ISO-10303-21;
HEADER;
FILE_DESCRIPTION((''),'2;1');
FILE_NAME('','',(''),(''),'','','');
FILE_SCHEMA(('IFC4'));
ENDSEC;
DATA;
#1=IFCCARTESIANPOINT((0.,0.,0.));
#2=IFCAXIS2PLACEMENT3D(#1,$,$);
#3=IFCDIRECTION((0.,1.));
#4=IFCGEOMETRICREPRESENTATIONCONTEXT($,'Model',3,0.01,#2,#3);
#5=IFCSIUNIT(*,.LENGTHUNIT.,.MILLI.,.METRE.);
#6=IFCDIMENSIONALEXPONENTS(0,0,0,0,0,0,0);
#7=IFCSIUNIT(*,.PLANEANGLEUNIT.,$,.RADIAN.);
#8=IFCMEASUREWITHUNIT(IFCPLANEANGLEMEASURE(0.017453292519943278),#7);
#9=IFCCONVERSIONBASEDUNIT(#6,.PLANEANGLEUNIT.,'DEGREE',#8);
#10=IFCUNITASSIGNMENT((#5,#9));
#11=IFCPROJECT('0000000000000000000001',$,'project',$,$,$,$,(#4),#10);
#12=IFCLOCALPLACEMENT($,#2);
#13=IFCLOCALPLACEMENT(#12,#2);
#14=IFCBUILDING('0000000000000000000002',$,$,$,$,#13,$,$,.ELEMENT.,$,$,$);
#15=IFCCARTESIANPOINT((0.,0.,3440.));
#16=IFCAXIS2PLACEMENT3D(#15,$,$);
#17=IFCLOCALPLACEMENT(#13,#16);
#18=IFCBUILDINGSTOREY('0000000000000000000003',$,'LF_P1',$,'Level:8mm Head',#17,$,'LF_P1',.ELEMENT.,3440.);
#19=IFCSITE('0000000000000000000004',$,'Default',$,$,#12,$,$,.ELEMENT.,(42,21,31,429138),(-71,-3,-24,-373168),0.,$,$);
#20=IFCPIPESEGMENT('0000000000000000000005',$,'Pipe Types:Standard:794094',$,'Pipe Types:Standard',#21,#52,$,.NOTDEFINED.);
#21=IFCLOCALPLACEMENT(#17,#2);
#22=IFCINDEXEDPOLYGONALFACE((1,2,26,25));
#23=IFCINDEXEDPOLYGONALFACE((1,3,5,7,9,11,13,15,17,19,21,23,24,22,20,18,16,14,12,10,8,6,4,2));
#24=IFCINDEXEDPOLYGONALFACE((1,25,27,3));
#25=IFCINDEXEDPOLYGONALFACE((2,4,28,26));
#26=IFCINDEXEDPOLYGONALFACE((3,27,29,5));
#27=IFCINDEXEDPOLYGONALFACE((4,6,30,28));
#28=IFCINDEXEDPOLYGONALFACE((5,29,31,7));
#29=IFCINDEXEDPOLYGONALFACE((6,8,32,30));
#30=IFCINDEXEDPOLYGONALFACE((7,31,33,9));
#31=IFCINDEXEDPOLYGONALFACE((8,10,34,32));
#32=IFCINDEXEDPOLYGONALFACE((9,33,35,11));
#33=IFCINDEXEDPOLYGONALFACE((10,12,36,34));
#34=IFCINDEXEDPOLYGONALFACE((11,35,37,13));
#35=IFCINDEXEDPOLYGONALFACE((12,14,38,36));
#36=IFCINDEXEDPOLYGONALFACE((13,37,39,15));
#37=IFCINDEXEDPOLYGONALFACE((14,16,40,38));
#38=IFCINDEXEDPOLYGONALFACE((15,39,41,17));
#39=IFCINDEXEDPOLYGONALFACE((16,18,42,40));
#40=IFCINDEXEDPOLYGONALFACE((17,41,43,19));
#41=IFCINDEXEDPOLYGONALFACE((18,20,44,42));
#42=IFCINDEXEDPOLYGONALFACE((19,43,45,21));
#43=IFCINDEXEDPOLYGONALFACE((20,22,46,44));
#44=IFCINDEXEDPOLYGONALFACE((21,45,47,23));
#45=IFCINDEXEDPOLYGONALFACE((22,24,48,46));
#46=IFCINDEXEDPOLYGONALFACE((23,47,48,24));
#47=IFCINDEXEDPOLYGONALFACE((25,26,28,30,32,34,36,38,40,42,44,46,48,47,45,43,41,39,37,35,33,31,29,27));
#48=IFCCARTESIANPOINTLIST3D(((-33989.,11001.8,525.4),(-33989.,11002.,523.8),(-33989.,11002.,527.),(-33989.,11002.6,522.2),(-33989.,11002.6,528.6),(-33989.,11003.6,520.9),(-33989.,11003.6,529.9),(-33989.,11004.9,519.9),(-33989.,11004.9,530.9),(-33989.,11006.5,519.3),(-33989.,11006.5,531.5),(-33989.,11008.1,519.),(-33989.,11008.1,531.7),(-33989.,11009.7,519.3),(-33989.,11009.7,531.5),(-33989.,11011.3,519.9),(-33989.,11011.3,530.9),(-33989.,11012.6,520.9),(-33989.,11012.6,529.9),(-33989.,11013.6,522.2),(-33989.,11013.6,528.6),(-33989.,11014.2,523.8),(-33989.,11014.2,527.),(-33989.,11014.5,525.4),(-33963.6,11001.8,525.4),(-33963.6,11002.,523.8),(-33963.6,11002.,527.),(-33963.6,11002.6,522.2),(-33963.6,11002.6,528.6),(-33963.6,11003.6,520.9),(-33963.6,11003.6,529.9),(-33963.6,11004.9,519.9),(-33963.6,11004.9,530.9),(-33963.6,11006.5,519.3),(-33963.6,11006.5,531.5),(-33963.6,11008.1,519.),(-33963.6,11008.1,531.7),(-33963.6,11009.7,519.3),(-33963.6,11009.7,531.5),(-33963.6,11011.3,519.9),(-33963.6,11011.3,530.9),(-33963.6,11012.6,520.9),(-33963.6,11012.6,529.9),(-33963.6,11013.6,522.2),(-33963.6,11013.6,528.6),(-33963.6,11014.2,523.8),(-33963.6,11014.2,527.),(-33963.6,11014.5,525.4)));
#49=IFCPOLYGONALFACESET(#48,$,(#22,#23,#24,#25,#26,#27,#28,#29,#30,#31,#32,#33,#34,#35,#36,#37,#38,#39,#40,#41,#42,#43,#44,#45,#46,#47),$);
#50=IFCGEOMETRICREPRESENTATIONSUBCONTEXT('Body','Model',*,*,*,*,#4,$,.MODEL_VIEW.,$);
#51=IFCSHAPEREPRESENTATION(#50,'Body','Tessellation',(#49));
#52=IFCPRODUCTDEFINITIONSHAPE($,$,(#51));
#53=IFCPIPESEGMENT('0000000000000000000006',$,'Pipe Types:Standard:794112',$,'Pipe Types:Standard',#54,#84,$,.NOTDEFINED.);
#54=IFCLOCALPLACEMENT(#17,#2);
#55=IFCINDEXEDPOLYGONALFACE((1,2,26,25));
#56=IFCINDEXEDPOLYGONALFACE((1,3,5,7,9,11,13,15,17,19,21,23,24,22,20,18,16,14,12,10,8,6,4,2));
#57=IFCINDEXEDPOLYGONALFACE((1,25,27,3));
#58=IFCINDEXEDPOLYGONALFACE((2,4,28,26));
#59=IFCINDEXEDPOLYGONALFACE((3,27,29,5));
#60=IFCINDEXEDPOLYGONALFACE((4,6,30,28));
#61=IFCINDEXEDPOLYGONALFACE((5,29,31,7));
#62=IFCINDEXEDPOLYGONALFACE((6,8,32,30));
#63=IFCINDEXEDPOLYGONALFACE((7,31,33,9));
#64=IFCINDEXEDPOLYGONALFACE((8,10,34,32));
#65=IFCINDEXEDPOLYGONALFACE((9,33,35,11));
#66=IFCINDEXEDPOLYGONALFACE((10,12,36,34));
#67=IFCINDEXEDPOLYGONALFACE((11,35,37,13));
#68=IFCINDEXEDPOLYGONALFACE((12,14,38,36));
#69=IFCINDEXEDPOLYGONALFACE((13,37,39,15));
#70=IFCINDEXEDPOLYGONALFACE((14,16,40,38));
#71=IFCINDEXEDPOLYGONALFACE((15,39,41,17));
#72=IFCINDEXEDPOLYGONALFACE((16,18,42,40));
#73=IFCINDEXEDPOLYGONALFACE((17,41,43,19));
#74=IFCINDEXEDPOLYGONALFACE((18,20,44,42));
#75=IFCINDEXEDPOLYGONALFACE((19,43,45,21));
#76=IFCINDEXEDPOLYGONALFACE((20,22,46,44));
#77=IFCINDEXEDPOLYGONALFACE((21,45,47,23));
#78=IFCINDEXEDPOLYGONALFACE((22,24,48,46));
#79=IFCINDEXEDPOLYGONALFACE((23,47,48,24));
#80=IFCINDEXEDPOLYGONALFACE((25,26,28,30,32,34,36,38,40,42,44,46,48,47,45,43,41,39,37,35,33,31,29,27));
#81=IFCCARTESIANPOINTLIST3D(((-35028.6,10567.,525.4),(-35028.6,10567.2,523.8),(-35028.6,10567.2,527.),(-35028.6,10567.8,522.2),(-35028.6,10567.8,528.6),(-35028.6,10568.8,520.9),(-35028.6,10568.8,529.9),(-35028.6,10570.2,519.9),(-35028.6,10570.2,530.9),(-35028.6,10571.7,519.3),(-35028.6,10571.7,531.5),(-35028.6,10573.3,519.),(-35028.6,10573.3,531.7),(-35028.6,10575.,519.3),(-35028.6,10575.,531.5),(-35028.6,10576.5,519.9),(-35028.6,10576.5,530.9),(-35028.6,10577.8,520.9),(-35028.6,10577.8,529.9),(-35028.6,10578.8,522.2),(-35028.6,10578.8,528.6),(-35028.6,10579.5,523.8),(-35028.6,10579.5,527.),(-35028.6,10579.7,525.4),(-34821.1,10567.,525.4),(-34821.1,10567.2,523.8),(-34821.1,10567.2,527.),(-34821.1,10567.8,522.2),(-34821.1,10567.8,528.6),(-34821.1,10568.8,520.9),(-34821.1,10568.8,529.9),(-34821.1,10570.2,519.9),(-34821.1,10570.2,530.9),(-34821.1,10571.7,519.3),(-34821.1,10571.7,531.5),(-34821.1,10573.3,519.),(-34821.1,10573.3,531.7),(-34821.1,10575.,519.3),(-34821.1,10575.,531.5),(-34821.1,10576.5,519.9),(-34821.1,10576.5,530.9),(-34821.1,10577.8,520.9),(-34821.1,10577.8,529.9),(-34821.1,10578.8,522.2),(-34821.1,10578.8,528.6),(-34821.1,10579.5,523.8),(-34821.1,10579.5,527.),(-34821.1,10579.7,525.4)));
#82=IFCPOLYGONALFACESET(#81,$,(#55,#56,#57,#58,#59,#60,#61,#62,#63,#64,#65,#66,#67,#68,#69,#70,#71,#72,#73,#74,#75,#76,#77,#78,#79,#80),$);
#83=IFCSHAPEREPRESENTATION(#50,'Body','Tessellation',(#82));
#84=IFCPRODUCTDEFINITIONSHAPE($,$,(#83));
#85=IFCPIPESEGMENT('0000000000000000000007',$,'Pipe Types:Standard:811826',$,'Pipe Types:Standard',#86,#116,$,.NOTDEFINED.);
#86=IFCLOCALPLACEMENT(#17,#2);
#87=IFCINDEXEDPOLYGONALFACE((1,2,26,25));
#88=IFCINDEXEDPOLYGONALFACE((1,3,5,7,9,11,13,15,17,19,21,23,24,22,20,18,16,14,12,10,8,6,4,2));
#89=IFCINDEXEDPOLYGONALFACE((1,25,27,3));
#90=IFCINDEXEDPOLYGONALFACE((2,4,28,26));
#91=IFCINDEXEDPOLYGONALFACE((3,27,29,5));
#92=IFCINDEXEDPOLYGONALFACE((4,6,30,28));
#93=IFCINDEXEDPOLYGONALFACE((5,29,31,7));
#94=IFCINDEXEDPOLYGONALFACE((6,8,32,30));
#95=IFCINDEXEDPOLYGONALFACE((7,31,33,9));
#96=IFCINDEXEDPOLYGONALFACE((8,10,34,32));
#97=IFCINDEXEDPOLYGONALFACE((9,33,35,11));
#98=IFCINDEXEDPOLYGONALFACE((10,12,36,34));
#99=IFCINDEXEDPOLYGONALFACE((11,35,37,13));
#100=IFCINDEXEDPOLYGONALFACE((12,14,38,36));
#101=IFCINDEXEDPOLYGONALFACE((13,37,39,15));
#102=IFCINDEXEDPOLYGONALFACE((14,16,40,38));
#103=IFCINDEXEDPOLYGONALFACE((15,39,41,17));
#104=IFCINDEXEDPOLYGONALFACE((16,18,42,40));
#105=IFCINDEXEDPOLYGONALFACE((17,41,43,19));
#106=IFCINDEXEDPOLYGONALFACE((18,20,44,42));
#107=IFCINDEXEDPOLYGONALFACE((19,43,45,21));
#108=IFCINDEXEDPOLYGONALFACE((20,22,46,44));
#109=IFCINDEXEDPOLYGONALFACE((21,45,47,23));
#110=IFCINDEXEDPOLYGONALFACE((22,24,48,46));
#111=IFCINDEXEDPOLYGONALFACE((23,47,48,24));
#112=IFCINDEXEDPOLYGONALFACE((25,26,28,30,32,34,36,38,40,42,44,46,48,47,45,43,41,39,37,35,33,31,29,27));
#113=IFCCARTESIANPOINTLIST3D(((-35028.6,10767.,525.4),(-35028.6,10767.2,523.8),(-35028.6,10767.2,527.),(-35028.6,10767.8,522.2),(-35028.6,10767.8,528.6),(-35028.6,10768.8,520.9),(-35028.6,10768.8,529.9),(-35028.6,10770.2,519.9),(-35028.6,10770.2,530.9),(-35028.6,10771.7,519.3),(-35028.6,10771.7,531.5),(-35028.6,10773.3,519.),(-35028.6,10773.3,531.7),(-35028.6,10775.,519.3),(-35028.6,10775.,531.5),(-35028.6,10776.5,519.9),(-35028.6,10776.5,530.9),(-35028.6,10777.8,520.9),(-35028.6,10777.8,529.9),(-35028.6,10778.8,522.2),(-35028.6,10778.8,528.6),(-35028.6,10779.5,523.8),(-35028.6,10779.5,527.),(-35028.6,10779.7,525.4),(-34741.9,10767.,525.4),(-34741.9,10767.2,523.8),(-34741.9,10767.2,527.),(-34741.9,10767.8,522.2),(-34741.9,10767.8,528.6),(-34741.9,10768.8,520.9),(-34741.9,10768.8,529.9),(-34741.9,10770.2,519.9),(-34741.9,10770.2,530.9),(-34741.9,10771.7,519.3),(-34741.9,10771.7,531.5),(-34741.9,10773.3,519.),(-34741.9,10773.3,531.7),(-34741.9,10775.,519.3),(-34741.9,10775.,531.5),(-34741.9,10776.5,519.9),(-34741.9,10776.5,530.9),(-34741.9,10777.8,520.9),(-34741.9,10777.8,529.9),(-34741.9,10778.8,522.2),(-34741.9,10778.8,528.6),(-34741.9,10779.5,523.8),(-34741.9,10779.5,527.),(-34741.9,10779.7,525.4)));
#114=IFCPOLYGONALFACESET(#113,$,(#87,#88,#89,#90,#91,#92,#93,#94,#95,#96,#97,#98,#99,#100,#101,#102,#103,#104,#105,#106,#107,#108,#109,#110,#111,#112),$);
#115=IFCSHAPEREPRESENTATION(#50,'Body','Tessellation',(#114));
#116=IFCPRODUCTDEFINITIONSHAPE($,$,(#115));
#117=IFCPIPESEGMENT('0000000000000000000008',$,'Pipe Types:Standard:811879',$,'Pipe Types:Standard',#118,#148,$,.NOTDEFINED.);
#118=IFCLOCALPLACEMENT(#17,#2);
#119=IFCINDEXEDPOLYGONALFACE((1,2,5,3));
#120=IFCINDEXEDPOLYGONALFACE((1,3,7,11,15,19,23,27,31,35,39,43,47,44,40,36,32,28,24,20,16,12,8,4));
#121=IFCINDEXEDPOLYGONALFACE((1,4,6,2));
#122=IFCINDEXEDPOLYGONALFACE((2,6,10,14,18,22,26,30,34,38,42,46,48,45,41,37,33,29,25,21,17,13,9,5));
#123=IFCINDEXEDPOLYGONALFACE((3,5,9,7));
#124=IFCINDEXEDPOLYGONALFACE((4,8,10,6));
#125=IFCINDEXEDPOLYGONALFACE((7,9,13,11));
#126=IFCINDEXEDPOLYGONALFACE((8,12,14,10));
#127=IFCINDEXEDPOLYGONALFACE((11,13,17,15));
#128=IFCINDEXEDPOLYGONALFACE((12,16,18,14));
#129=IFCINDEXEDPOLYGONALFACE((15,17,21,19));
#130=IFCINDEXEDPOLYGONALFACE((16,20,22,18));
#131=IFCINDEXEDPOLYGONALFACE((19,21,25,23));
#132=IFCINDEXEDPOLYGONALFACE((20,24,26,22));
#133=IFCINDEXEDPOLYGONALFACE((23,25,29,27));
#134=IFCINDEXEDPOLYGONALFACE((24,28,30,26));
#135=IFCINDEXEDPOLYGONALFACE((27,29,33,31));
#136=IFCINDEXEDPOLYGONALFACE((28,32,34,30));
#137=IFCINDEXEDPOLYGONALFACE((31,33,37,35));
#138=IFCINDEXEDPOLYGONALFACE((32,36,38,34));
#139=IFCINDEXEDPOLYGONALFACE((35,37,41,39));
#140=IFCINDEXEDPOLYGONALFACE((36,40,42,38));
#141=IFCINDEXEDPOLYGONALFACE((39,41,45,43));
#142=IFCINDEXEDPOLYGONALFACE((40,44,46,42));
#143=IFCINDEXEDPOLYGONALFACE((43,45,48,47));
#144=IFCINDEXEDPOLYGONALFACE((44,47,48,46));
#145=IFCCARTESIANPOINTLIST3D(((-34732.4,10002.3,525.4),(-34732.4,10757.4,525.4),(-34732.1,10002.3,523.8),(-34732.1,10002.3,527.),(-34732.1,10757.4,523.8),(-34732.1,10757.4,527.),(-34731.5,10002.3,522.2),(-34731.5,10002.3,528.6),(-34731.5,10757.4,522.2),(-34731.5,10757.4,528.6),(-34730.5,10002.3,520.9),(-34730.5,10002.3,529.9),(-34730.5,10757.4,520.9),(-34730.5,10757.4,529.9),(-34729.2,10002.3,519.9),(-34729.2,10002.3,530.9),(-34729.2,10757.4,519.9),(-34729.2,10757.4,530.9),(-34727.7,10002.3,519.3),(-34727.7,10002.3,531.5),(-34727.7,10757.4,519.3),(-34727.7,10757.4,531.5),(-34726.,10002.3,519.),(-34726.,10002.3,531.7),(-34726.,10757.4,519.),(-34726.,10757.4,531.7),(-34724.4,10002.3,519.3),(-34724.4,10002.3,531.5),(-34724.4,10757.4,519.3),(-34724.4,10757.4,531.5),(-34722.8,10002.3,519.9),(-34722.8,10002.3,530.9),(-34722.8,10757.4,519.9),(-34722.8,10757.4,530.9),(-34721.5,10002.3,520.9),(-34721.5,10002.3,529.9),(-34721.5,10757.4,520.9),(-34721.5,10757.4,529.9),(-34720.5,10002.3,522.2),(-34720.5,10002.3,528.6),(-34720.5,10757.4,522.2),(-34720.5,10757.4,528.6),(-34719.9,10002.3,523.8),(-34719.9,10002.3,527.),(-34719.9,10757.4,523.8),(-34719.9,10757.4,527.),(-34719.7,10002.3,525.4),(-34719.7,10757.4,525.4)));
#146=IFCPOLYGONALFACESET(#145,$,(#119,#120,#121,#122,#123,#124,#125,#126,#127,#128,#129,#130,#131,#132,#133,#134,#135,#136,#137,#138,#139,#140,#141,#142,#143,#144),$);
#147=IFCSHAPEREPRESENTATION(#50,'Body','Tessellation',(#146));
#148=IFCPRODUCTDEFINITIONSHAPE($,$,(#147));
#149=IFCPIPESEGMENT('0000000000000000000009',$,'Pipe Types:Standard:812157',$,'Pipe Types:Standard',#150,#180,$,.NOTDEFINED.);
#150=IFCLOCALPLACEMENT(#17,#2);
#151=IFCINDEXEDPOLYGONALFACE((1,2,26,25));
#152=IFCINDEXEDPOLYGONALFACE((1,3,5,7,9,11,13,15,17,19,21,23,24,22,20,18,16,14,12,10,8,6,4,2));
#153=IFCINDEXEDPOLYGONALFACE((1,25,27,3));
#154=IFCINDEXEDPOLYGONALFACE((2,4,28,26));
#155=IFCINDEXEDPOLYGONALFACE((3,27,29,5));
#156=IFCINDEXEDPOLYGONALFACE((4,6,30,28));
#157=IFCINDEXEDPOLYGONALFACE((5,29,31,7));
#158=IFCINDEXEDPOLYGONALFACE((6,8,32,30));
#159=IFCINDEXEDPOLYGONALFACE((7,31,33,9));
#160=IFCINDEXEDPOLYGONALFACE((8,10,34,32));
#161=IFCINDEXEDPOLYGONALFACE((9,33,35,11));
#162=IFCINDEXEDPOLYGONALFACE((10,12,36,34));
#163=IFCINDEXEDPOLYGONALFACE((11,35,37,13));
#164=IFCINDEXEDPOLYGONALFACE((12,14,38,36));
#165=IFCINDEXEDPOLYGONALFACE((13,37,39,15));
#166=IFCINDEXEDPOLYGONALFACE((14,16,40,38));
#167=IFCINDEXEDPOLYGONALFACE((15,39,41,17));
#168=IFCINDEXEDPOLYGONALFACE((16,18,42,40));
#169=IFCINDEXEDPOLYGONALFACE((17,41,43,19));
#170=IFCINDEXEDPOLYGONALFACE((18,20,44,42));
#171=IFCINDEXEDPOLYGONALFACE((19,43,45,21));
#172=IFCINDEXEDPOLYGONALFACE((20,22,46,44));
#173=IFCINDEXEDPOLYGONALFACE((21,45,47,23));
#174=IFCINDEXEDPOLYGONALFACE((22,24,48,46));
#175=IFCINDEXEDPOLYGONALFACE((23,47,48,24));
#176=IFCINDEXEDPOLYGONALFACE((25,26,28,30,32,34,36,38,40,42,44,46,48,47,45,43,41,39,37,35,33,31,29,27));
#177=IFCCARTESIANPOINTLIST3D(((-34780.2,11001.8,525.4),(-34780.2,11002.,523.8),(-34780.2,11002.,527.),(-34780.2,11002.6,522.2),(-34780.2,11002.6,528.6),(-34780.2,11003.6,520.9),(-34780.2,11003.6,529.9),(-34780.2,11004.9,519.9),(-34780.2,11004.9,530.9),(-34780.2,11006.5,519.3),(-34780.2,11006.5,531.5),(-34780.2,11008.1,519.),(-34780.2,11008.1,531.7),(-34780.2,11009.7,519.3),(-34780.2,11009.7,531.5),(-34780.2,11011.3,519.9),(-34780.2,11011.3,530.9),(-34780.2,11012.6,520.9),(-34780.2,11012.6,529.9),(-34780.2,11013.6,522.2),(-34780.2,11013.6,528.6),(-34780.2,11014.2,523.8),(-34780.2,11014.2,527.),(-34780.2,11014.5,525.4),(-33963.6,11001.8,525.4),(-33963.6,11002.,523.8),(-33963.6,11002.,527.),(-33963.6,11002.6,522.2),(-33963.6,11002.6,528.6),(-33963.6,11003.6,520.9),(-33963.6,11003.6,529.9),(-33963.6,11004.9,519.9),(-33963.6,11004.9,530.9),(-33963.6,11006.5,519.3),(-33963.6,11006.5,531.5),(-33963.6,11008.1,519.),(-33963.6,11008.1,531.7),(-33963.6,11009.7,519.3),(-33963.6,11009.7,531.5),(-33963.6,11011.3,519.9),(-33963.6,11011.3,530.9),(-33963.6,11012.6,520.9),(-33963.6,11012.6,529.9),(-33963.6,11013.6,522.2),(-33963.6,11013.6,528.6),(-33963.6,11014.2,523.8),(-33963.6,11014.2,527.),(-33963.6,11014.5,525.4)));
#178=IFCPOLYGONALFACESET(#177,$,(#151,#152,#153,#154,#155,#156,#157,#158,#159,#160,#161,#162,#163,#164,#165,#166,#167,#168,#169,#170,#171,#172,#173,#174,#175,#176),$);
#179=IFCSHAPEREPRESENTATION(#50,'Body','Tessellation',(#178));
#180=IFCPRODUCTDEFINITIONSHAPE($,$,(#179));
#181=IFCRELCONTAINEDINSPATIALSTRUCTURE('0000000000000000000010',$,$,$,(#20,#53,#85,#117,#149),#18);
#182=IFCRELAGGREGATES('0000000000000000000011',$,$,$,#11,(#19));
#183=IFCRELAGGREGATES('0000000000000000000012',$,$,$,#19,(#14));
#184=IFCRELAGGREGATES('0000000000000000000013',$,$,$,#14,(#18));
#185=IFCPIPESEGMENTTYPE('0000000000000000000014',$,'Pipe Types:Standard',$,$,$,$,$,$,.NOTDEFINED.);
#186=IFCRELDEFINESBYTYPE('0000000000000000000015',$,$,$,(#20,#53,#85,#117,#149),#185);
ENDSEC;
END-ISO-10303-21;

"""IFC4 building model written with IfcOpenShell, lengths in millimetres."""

from ifc_helpers import new_model, entity, si_unit, converted_unit, direction, frame, origin, place, context, subcontext, project, spatial, arc, indexed_curve, outline, extrude, type_object, element, save


model = new_model("IFC4")

# Units and contexts
model_context = context("Model", 3, precision=0.01, world=origin(), true_north=direction((0.0, 1.0)))
body_context = subcontext(model_context, "Body", "Model", "MODEL_VIEW")
ifc_project = project(units=[si_unit("LENGTHUNIT", "METRE", prefix="MILLI"), converted_unit("PLANEANGLEUNIT", "DEGREE", entity("IfcPlaneAngleMeasure", 0.017453292519943278), si_unit("PLANEANGLEUNIT", "RADIAN"), dimensions=[0, 0, 0, 0, 0, 0, 0])], contexts=[model_context])

# Site, building, storey
site_placement = place(None, origin())
site = spatial("IfcSite", under=ifc_project, at=site_placement, Name="Default", CompositionType="ELEMENT", RefLatitude=(42, 21, 31, 429138), RefLongitude=(-71, -3, -24, -373168), RefElevation=0.0)
building_placement = place(site_placement, origin())
building = spatial("IfcBuilding", under=site, at=building_placement, CompositionType="ELEMENT")
storey_placement = place(building_placement, frame((0.0, 0.0, 3440.0)))
storey = spatial("IfcBuildingStorey", under=building, at=storey_placement, Name="LF_P1", ObjectType="Level:8mm Head", LongName="LF_P1", CompositionType="ELEMENT", Elevation=3440.0)

# Pipe segments
pipe_segment_type_1 = type_object("IfcPipeSegmentType", Name="Pipe Types:Standard", PredefinedType="NOTDEFINED")
pipe_segment_1_placement = place(storey_placement, origin())
element("IfcPipeSegment", 1, at=pipe_segment_1_placement, inside=storey, type_object=pipe_segment_type_1, Name="Pipe Types:Standard:794094", ObjectType="Pipe Types:Standard", PredefinedType="NOTDEFINED", context=body_context, shape_type="SweptSolid", body=[
    extrude(outline(indexed_curve([(6.4, 0.0), (4.5, 4.5), (0.0, 6.4), (-4.5, 4.5), (-6.3, 0.0), (-4.5, -4.5), (0.0, -6.4), (4.5, -4.5)], segments=[arc(1, 2, 3), arc(3, 4, 5), arc(5, 6, 7), arc(7, 8, 1)], self_intersect=False)), frame((-33989.0, 11008.1, 525.4), z_axis=(1.0, 0.0, 0.0), x_axis=(0.0, 1.0, 0.0)), (0.0, 0.0, 1.0), 25.4),
])
pipe_segment_2_placement = place(storey_placement, origin())
element("IfcPipeSegment", 2, at=pipe_segment_2_placement, inside=storey, type_object=pipe_segment_type_1, Name="Pipe Types:Standard:794112", ObjectType="Pipe Types:Standard", PredefinedType="NOTDEFINED", context=body_context, shape_type="SweptSolid", body=[
    extrude(outline(indexed_curve([(6.4, 0.0), (4.5, 4.5), (0.0, 6.4), (-4.5, 4.5), (-6.4, 0.0), (-4.5, -4.5), (0.0, -6.4), (4.5, -4.5)], segments=[arc(1, 2, 3), arc(3, 4, 5), arc(5, 6, 7), arc(7, 8, 1)], self_intersect=False)), frame((-35028.6, 10573.3, 525.4), z_axis=(1.0, 0.0, 0.0), x_axis=(0.0, -1.0, 0.0)), (0.0, 0.0, 1.0), 207.5),
])
pipe_segment_3_placement = place(storey_placement, origin())
element("IfcPipeSegment", 3, at=pipe_segment_3_placement, inside=storey, type_object=pipe_segment_type_1, Name="Pipe Types:Standard:811826", ObjectType="Pipe Types:Standard", PredefinedType="NOTDEFINED", context=body_context, shape_type="SweptSolid", body=[
    extrude(outline(indexed_curve([(6.4, 0.0), (4.5, 4.5), (0.0, 6.4), (-4.5, 4.5), (-6.4, 0.0), (-4.5, -4.5), (0.0, -6.4), (4.5, -4.5)], segments=[arc(1, 2, 3), arc(3, 4, 5), arc(5, 6, 7), arc(7, 8, 1)], self_intersect=False)), frame((-35028.6, 10773.3, 525.4), z_axis=(1.0, 0.0, 0.0), x_axis=(0.0, -1.0, 0.0)), (0.0, 0.0, 1.0), 286.7),
])
pipe_segment_4_placement = place(storey_placement, origin())
element("IfcPipeSegment", 4, at=pipe_segment_4_placement, inside=storey, type_object=pipe_segment_type_1, Name="Pipe Types:Standard:811879", ObjectType="Pipe Types:Standard", PredefinedType="NOTDEFINED", context=body_context, shape_type="SweptSolid", body=[
    extrude(outline(indexed_curve([(6.3, 0.0), (4.5, 4.5), (0.0, 6.3), (-4.5, 4.5), (-6.3, 0.0), (-4.5, -4.5), (0.0, -6.4), (4.5, -4.5)], segments=[arc(1, 2, 3), arc(3, 4, 5), arc(5, 6, 7), arc(7, 8, 1)], self_intersect=False)), frame((-34726.0, 10002.3, 525.4), z_axis=(0.0, 1.0, 0.0), x_axis=(-1.0, 0.0, 0.0)), (0.0, 0.0, 1.0), 755.1),
])
pipe_segment_5_placement = place(storey_placement, origin())
element("IfcPipeSegment", 5, at=pipe_segment_5_placement, inside=storey, type_object=pipe_segment_type_1, Name="Pipe Types:Standard:812157", ObjectType="Pipe Types:Standard", PredefinedType="NOTDEFINED", context=body_context, shape_type="SweptSolid", body=[
    extrude(outline(indexed_curve([(6.3, 0.0), (4.5, 4.5), (0.0, 6.4), (-4.5, 4.5), (-6.4, 0.0), (-4.5, -4.5), (0.0, -6.4), (4.5, -4.5)], segments=[arc(1, 2, 3), arc(3, 4, 5), arc(5, 6, 7), arc(7, 8, 1)], self_intersect=False)), frame((-34780.2, 11008.1, 525.4), z_axis=(1.0, 0.0, 0.0), x_axis=(0.0, 1.0, 0.0)), (0.0, 0.0, 1.0), 816.6),
])

save(model, "model.ifc")
